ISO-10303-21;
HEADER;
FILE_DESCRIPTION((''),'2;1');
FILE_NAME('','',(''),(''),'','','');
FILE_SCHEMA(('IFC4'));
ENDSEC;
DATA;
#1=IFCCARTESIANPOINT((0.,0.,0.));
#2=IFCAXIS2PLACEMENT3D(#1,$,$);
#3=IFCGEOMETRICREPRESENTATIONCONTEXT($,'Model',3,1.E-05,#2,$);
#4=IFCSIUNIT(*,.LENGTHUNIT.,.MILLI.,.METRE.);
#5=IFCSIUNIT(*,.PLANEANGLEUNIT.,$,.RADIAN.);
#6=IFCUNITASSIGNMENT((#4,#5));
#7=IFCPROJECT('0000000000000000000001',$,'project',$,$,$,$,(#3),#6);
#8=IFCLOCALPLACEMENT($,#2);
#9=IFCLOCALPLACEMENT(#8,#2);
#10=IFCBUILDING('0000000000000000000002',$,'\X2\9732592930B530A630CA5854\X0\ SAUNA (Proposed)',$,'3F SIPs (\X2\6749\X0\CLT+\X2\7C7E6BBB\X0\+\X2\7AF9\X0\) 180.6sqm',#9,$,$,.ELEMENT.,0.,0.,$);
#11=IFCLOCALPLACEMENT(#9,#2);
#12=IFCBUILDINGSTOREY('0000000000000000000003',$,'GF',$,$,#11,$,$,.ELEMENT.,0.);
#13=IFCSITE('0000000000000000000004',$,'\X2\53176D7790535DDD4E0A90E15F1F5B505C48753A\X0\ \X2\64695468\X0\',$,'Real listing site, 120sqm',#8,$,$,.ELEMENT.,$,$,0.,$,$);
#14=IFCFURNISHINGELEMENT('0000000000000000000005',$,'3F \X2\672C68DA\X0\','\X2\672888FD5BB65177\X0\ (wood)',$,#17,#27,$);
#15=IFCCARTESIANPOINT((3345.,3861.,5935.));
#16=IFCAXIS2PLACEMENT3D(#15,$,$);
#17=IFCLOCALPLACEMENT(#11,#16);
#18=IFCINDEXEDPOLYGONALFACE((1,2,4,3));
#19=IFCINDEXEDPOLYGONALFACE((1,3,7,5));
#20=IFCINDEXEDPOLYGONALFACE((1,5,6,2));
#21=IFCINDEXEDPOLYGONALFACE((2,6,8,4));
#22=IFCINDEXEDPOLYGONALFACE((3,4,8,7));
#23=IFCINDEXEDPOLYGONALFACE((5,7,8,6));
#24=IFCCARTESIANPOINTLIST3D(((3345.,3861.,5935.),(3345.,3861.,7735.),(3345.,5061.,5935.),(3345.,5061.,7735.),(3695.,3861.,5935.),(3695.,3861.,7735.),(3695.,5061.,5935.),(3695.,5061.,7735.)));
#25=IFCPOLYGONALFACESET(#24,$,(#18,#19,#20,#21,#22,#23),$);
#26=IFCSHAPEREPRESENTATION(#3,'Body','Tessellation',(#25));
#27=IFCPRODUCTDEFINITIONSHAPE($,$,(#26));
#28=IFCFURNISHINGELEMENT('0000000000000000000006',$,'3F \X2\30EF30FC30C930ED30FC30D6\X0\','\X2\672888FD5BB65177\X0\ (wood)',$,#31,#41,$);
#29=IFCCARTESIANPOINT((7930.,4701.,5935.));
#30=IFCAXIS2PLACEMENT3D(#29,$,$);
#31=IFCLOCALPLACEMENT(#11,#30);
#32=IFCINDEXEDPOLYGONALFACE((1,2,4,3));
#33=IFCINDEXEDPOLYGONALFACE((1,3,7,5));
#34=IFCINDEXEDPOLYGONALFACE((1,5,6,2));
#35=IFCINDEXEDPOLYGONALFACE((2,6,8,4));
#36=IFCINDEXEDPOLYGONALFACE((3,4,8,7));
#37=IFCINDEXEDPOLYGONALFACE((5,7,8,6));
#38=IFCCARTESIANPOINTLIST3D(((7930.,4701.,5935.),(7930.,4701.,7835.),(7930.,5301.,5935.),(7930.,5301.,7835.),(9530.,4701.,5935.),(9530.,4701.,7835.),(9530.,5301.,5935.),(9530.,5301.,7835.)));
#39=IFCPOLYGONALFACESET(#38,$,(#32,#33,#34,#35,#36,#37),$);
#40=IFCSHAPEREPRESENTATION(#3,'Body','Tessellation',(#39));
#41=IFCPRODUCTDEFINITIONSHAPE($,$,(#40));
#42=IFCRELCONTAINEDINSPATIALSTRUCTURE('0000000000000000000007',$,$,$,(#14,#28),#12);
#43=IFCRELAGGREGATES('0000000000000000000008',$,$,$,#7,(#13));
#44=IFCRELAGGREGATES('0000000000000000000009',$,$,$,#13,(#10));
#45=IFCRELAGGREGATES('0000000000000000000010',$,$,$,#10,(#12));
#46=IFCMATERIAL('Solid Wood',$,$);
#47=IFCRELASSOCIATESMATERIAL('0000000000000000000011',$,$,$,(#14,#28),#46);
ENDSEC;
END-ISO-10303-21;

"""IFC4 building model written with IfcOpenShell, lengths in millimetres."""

from ifc_helpers import new_model, si_unit, frame, frame_2d, origin, place, context, project, spatial, rectangle, extrude, material, element, save


model = new_model("IFC4")

# Units and contexts
model_context = context("Model", 3, precision=1e-05, world=origin())
ifc_project = project(units=[si_unit("LENGTHUNIT", "METRE", prefix="MILLI"), si_unit("PLANEANGLEUNIT", "RADIAN")], contexts=[model_context])

# Site, building, storey
site_placement = place(None, origin())
site = spatial("IfcSite", under=ifc_project, at=site_placement, Name="北海道川上郡弟子屈町 摩周", ObjectType="Real listing site, 120sqm", CompositionType="ELEMENT", RefElevation=0.0)
building_placement = place(site_placement, origin())
building = spatial("IfcBuilding", under=site, at=building_placement, Name="露天サウナ塔 SAUNA (Proposed)", ObjectType="3F SIPs (杉CLT+籾殻+竹) 180.6sqm", CompositionType="ELEMENT", ElevationOfRefHeight=0.0, ElevationOfTerrain=0.0)
storey_placement = place(building_placement, origin())
storey = spatial("IfcBuildingStorey", under=building, at=storey_placement, Name="GF", CompositionType="ELEMENT", Elevation=0.0)

# Shared definitions
ifc_material_1 = material(Name="Solid Wood")

# Furnishing elements
furnishing_1_placement = place(storey_placement, frame((3345.0, 3861.0, 5935.0)))
element("IfcFurnishingElement", 1, at=furnishing_1_placement, inside=storey, material=ifc_material_1, Name="3F 本棚", Description="木製家具 (wood)", context=model_context, shape_type="SweptSolid", body=[
    extrude(rectangle(XDim=350.0, YDim=1200.0, at=frame_2d((175.0, 600.0))), frame((3345.0, 3861.0, 5935.0)), (0.0, 0.0, 1.0), 1800.0),
])
furnishing_2_placement = place(storey_placement, frame((7930.0, 4701.0, 5935.0)))
element("IfcFurnishingElement", 2, at=furnishing_2_placement, inside=storey, material=ifc_material_1, Name="3F ワードローブ", Description="木製家具 (wood)", context=model_context, shape_type="SweptSolid", body=[
    extrude(rectangle(XDim=1600.0, YDim=600.0, at=frame_2d((800.0, 300.0))), frame((7930.0, 4701.0, 5935.0)), (0.0, 0.0, 1.0), 1900.0),
])

save(model, "model.ifc")
